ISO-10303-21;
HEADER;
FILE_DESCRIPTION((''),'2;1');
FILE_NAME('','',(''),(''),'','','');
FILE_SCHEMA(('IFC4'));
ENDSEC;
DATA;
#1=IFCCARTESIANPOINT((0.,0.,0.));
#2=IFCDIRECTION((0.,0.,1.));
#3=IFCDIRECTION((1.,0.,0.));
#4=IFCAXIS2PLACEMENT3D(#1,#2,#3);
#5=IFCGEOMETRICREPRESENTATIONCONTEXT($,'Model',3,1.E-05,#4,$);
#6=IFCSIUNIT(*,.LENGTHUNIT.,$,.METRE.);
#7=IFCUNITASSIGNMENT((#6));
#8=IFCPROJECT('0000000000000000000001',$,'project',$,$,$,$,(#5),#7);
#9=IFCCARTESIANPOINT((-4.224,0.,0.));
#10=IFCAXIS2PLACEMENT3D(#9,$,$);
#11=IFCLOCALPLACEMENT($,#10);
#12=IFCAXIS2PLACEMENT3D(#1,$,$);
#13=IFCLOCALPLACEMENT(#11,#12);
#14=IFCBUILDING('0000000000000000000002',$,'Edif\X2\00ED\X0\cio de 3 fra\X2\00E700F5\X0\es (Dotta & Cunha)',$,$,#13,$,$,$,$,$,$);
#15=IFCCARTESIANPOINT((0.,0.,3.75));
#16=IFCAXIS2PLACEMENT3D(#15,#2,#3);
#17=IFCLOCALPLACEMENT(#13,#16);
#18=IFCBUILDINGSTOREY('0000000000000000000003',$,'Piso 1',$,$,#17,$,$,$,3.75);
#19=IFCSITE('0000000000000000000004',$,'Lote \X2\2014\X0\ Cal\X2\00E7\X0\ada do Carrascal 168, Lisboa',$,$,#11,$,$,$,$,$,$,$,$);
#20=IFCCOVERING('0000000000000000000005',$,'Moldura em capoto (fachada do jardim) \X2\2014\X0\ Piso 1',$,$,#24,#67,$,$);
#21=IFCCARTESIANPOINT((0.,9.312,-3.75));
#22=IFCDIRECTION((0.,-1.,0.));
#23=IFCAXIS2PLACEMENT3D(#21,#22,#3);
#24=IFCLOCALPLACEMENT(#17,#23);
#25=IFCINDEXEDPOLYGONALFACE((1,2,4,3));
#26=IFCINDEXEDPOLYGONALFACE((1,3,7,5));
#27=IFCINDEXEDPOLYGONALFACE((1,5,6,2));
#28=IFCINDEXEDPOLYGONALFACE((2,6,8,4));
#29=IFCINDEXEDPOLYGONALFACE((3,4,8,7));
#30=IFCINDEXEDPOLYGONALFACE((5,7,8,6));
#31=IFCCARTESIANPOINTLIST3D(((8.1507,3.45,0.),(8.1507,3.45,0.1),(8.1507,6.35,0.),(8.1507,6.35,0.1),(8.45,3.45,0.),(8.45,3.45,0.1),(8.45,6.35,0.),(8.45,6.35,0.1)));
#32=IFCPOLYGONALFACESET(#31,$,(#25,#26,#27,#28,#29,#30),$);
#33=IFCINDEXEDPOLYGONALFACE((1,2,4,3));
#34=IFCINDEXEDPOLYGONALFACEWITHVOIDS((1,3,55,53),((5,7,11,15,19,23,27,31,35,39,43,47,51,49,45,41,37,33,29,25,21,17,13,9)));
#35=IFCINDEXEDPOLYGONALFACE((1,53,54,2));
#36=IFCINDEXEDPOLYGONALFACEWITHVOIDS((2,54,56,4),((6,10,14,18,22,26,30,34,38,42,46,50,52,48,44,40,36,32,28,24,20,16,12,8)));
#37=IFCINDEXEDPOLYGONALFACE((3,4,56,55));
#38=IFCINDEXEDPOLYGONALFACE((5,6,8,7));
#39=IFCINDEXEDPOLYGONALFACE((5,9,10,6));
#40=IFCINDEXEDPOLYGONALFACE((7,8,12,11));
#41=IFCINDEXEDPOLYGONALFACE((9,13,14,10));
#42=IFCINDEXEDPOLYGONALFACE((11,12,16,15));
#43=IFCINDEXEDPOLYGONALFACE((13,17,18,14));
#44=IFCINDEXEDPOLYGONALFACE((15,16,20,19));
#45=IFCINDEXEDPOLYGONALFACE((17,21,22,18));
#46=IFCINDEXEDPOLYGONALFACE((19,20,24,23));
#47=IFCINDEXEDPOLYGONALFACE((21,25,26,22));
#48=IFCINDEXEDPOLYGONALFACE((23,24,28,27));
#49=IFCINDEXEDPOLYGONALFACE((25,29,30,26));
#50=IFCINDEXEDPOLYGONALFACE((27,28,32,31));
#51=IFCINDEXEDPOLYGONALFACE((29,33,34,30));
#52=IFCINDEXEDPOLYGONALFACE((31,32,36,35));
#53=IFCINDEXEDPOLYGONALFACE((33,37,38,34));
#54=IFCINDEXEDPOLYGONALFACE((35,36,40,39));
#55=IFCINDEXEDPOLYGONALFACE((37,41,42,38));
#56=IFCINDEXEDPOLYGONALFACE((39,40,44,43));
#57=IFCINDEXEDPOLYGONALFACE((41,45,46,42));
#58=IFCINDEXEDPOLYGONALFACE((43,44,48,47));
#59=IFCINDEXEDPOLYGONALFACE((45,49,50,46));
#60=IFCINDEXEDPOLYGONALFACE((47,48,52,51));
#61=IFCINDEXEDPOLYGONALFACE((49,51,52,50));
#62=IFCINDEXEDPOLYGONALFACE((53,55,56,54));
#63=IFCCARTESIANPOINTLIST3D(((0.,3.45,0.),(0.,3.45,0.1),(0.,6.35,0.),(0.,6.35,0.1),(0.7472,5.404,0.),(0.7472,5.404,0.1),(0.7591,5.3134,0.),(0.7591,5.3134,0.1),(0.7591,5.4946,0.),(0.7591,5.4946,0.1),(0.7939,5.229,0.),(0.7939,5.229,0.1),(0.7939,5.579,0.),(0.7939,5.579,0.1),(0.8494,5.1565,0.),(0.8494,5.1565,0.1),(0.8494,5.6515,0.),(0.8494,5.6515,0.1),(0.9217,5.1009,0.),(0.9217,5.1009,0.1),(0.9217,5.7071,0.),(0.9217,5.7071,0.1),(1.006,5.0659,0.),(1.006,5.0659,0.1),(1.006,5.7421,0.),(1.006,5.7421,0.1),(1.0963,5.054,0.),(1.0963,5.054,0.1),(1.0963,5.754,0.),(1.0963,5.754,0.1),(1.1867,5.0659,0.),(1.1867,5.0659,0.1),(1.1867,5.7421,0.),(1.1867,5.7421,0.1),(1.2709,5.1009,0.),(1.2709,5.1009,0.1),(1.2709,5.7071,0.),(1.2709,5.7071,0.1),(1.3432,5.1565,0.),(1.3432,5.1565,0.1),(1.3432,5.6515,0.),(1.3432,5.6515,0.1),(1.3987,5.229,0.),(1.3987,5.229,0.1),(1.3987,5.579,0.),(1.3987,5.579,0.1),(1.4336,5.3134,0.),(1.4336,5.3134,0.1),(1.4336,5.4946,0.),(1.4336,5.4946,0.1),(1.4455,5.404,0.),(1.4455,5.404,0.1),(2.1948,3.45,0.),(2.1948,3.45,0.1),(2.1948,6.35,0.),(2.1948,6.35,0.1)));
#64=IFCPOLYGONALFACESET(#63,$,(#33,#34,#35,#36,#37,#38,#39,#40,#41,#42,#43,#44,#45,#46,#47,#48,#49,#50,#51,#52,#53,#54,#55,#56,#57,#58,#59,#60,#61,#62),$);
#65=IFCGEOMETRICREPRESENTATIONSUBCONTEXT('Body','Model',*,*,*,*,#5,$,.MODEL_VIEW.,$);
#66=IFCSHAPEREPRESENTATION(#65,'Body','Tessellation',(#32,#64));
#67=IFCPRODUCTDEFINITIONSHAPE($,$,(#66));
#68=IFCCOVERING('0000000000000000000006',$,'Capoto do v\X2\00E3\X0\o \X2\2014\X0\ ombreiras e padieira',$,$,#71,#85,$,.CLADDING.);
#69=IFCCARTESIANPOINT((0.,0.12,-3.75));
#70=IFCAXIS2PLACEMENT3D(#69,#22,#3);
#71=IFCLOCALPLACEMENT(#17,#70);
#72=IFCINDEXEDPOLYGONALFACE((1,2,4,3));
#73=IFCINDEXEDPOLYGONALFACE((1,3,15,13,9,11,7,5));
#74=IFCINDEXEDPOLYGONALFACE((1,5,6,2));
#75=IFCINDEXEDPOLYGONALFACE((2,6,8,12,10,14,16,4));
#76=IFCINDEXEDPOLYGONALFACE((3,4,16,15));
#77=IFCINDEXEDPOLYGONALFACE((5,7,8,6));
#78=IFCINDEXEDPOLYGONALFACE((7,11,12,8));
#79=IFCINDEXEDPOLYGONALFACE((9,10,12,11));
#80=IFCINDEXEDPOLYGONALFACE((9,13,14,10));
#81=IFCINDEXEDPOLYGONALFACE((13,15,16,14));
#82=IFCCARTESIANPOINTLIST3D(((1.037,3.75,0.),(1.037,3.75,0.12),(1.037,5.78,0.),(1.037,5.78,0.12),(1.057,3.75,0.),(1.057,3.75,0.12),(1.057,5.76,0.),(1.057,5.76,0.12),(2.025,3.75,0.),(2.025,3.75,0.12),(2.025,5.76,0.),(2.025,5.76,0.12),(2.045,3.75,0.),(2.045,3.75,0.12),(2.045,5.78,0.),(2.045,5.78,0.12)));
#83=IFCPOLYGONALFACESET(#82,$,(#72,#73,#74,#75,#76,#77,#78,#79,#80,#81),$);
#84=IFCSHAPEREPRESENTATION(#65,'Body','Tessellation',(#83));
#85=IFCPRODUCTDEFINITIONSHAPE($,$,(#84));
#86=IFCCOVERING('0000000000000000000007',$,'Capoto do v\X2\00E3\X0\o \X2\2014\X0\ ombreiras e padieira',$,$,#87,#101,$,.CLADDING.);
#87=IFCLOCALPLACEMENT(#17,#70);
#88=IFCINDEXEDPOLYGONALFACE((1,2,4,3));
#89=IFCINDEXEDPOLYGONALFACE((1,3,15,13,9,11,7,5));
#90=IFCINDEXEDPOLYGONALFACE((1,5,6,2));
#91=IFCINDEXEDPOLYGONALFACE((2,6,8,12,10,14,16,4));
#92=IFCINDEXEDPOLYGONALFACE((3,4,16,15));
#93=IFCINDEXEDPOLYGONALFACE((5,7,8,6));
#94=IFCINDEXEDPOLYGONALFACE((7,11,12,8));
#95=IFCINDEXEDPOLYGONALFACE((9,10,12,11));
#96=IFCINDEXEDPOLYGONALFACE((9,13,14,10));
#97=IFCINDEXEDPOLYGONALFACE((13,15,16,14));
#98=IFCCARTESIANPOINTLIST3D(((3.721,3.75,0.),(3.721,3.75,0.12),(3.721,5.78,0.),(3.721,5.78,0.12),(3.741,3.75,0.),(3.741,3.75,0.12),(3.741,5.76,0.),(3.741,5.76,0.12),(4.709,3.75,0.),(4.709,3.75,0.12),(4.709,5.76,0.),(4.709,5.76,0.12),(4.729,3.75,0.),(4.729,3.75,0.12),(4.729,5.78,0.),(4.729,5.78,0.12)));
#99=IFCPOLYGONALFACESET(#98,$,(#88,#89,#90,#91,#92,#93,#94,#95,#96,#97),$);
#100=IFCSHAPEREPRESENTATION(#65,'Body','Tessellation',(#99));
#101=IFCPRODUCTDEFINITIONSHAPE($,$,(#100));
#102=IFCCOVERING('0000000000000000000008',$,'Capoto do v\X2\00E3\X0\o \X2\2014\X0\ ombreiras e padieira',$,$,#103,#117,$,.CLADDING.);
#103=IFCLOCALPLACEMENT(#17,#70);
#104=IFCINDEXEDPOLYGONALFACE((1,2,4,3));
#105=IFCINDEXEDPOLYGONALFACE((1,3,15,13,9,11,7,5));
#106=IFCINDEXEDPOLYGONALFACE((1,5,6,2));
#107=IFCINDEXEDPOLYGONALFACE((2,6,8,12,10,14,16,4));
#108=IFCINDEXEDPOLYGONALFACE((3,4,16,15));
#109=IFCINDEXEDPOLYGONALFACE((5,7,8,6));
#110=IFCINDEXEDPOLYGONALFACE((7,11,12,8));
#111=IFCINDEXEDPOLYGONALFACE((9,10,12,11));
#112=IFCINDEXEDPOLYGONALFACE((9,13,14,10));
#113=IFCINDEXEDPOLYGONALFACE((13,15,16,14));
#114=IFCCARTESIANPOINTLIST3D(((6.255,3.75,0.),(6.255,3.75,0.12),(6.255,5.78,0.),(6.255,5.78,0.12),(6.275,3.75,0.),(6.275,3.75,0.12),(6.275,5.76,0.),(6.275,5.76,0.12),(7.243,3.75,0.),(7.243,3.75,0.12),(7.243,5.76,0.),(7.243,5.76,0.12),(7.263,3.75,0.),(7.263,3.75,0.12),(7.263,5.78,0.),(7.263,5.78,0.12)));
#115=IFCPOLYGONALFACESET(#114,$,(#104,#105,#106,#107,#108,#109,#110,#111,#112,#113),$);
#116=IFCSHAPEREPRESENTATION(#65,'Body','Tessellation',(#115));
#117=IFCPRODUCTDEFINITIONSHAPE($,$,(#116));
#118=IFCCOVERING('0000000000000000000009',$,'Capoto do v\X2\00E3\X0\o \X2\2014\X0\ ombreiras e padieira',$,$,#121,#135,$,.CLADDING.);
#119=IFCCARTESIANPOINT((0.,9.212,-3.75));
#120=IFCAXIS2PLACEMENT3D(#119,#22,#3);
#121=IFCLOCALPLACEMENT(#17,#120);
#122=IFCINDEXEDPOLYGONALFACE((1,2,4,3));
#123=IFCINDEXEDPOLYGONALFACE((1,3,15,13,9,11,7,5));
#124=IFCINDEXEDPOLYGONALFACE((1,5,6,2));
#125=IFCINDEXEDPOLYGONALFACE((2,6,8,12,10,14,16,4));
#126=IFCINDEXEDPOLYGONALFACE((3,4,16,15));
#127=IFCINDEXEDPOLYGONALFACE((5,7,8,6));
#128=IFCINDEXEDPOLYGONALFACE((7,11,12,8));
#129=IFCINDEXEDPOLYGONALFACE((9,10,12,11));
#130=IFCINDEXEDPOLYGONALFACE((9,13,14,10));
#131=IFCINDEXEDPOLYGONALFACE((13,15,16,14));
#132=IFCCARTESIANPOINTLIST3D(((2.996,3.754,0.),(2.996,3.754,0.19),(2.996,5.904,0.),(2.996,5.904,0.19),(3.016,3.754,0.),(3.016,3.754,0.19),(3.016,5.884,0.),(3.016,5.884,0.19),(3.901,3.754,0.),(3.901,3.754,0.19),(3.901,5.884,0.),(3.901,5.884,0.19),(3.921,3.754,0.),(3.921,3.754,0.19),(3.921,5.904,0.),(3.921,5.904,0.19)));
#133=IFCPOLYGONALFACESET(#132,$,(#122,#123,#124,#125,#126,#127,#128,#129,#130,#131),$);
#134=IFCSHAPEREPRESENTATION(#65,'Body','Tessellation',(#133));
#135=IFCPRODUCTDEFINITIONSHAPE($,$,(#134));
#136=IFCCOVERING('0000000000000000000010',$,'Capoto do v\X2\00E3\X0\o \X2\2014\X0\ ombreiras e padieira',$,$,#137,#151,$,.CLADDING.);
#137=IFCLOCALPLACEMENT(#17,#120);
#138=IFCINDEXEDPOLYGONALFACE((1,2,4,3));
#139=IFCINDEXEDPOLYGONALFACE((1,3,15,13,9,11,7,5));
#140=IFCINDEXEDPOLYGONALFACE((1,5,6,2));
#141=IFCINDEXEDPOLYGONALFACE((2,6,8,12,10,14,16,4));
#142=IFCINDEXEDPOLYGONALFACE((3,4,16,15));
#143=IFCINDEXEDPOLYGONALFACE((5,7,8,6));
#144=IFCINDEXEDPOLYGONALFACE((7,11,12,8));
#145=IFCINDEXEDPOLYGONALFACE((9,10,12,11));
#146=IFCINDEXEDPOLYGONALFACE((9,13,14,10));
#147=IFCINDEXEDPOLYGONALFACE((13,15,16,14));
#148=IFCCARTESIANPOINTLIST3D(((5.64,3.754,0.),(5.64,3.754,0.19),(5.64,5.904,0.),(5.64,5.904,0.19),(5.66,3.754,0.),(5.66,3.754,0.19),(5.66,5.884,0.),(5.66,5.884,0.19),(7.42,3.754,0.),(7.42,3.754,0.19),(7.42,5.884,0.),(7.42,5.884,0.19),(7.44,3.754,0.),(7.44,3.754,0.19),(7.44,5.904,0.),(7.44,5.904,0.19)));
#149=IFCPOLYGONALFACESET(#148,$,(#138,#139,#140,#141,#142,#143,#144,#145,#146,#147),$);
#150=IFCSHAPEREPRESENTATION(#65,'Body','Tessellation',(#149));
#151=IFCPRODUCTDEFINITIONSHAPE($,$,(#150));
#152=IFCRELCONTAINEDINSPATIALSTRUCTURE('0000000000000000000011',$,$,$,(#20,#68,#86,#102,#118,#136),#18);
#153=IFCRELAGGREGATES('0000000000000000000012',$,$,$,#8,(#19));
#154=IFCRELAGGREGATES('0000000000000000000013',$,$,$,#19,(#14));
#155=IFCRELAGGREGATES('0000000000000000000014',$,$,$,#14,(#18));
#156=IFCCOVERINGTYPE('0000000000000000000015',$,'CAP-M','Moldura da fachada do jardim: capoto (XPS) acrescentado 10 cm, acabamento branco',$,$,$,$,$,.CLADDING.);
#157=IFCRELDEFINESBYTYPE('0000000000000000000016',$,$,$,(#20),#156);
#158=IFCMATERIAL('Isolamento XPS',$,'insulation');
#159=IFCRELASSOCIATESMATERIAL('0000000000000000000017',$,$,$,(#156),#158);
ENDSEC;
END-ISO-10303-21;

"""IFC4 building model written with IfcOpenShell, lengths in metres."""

from ifc_helpers import new_model, si_unit, frame, origin, origin_with_axes, place, context, subcontext, project, spatial, line, indexed_curve, outline, extrude, material, type_object, element, save


model = new_model("IFC4")

# Units and contexts
model_context = context("Model", 3, precision=1e-05, world=origin_with_axes())
body_context = subcontext(model_context, "Body", "Model", "MODEL_VIEW")
ifc_project = project(units=[si_unit("LENGTHUNIT", "METRE")], contexts=[model_context])

# Site, building, storey
site_placement = place(None, frame((-4.224, 0.0, 0.0)))
site = spatial("IfcSite", under=ifc_project, at=site_placement, Name="Lote — Calçada do Carrascal 168, Lisboa")
building_placement = place(site_placement, origin())
building = spatial("IfcBuilding", under=site, at=building_placement, Name="Edifício de 3 frações (Dotta & Cunha)")
storey_placement = place(building_placement, frame((0.0, 0.0, 3.75), z_axis=(0.0, 0.0, 1.0), x_axis=(1.0, 0.0, 0.0)))
storey = spatial("IfcBuildingStorey", under=building, at=storey_placement, Name="Piso 1", Elevation=3.75)

# Covering
ifc_material_1 = material(Name="Isolamento XPS", Category="insulation")
covering_type_1 = type_object("IfcCoveringType", Name="CAP-M", Description="Moldura da fachada do jardim: capoto (XPS) acrescentado 10 cm, acabamento branco", PredefinedType="CLADDING", material=ifc_material_1)
covering_1_placement = place(storey_placement, frame((0.0, 9.312, -3.75), z_axis=(0.0, -1.0, 0.0), x_axis=(1.0, 0.0, 0.0)))
element("IfcCovering", 1, at=covering_1_placement, inside=storey, type_object=covering_type_1, Name="Moldura em capoto (fachada do jardim) — Piso 1", context=body_context, shape_type="SweptSolid", body=[
    extrude(outline(indexed_curve([(8.45, 3.45), (8.1507, 3.45), (8.1507, 6.35), (8.45, 6.35)], segments=[line(1, 2, 3, 4, 1)])), origin_with_axes(), (0.0, 0.0, 1.0), 0.1),
    extrude(outline(indexed_curve([(2.1948, 3.45), (0.0, 3.45), (0.0, 6.35), (2.1948, 6.35)], segments=[line(1, 2, 3, 4, 1)]), holes=[indexed_curve([(0.9217, 5.7071), (0.8494, 5.6515), (0.7939, 5.579), (0.7591, 5.4946), (0.7472, 5.404), (0.7591, 5.3134), (0.7939, 5.229), (0.8494, 5.1565), (0.9217, 5.1009), (1.006, 5.0659), (1.0963, 5.054), (1.1867, 5.0659), (1.2709, 5.1009), (1.3432, 5.1565), (1.3987, 5.229), (1.4336, 5.3134), (1.4455, 5.404), (1.4336, 5.4946), (1.3987, 5.579), (1.3432, 5.6515), (1.2709, 5.7071), (1.1867, 5.7421), (1.0963, 5.754), (1.006, 5.7421)], segments=[line(1, 2, 3, 4, 5, 6, 7, 8, 9, 10, 11, 12, 13, 14, 15, 16, 17, 18, 19, 20, 21, 22, 23, 24, 1)])]), origin_with_axes(), (0.0, 0.0, 1.0), 0.1),
])

# Coverings
covering_2_placement = place(storey_placement, frame((0.0, 0.12, -3.75), z_axis=(0.0, -1.0, 0.0), x_axis=(1.0, 0.0, 0.0)))
element("IfcCovering", 2, at=covering_2_placement, inside=storey, Name="Capoto do vão — ombreiras e padieira", PredefinedType="CLADDING", context=body_context, shape_type="SweptSolid", body=[
    extrude(outline(indexed_curve([(1.037, 3.75), (1.037, 5.78), (2.045, 5.78), (2.045, 3.75), (2.025, 3.75), (2.025, 5.76), (1.057, 5.76), (1.057, 3.75)], segments=[line(1, 2, 3, 4, 5, 6, 7, 8, 1)])), origin_with_axes(), (0.0, 0.0, 1.0), 0.12),
])
covering_3_placement = place(storey_placement, frame((0.0, 0.12, -3.75), z_axis=(0.0, -1.0, 0.0), x_axis=(1.0, 0.0, 0.0)))
element("IfcCovering", 3, at=covering_3_placement, inside=storey, Name="Capoto do vão — ombreiras e padieira", PredefinedType="CLADDING", context=body_context, shape_type="SweptSolid", body=[
    extrude(outline(indexed_curve([(3.721, 3.75), (3.721, 5.78), (4.729, 5.78), (4.729, 3.75), (4.709, 3.75), (4.709, 5.76), (3.741, 5.76), (3.741, 3.75)], segments=[line(1, 2, 3, 4, 5, 6, 7, 8, 1)])), origin_with_axes(), (0.0, 0.0, 1.0), 0.12),
])
covering_4_placement = place(storey_placement, frame((0.0, 0.12, -3.75), z_axis=(0.0, -1.0, 0.0), x_axis=(1.0, 0.0, 0.0)))
element("IfcCovering", 4, at=covering_4_placement, inside=storey, Name="Capoto do vão — ombreiras e padieira", PredefinedType="CLADDING", context=body_context, shape_type="SweptSolid", body=[
    extrude(outline(indexed_curve([(6.255, 3.75), (6.255, 5.78), (7.263, 5.78), (7.263, 3.75), (7.243, 3.75), (7.243, 5.76), (6.275, 5.76), (6.275, 3.75)], segments=[line(1, 2, 3, 4, 5, 6, 7, 8, 1)])), origin_with_axes(), (0.0, 0.0, 1.0), 0.12),
])
covering_5_placement = place(storey_placement, frame((0.0, 9.212, -3.75), z_axis=(0.0, -1.0, 0.0), x_axis=(1.0, 0.0, 0.0)))
element("IfcCovering", 5, at=covering_5_placement, inside=storey, Name="Capoto do vão — ombreiras e padieira", PredefinedType="CLADDING", context=body_context, shape_type="SweptSolid", body=[
    extrude(outline(indexed_curve([(2.996, 3.754), (2.996, 5.904), (3.921, 5.904), (3.921, 3.754), (3.901, 3.754), (3.901, 5.884), (3.016, 5.884), (3.016, 3.754)], segments=[line(1, 2, 3, 4, 5, 6, 7, 8, 1)])), origin_with_axes(), (0.0, 0.0, 1.0), 0.19),
])
covering_6_placement = place(storey_placement, frame((0.0, 9.212, -3.75), z_axis=(0.0, -1.0, 0.0), x_axis=(1.0, 0.0, 0.0)))
element("IfcCovering", 6, at=covering_6_placement, inside=storey, Name="Capoto do vão — ombreiras e padieira", PredefinedType="CLADDING", context=body_context, shape_type="SweptSolid", body=[
    extrude(outline(indexed_curve([(5.64, 3.754), (5.64, 5.904), (7.44, 5.904), (7.44, 3.754), (7.42, 3.754), (7.42, 5.884), (5.66, 5.884), (5.66, 3.754)], segments=[line(1, 2, 3, 4, 5, 6, 7, 8, 1)])), origin_with_axes(), (0.0, 0.0, 1.0), 0.19),
])

save(model, "model.ifc")
